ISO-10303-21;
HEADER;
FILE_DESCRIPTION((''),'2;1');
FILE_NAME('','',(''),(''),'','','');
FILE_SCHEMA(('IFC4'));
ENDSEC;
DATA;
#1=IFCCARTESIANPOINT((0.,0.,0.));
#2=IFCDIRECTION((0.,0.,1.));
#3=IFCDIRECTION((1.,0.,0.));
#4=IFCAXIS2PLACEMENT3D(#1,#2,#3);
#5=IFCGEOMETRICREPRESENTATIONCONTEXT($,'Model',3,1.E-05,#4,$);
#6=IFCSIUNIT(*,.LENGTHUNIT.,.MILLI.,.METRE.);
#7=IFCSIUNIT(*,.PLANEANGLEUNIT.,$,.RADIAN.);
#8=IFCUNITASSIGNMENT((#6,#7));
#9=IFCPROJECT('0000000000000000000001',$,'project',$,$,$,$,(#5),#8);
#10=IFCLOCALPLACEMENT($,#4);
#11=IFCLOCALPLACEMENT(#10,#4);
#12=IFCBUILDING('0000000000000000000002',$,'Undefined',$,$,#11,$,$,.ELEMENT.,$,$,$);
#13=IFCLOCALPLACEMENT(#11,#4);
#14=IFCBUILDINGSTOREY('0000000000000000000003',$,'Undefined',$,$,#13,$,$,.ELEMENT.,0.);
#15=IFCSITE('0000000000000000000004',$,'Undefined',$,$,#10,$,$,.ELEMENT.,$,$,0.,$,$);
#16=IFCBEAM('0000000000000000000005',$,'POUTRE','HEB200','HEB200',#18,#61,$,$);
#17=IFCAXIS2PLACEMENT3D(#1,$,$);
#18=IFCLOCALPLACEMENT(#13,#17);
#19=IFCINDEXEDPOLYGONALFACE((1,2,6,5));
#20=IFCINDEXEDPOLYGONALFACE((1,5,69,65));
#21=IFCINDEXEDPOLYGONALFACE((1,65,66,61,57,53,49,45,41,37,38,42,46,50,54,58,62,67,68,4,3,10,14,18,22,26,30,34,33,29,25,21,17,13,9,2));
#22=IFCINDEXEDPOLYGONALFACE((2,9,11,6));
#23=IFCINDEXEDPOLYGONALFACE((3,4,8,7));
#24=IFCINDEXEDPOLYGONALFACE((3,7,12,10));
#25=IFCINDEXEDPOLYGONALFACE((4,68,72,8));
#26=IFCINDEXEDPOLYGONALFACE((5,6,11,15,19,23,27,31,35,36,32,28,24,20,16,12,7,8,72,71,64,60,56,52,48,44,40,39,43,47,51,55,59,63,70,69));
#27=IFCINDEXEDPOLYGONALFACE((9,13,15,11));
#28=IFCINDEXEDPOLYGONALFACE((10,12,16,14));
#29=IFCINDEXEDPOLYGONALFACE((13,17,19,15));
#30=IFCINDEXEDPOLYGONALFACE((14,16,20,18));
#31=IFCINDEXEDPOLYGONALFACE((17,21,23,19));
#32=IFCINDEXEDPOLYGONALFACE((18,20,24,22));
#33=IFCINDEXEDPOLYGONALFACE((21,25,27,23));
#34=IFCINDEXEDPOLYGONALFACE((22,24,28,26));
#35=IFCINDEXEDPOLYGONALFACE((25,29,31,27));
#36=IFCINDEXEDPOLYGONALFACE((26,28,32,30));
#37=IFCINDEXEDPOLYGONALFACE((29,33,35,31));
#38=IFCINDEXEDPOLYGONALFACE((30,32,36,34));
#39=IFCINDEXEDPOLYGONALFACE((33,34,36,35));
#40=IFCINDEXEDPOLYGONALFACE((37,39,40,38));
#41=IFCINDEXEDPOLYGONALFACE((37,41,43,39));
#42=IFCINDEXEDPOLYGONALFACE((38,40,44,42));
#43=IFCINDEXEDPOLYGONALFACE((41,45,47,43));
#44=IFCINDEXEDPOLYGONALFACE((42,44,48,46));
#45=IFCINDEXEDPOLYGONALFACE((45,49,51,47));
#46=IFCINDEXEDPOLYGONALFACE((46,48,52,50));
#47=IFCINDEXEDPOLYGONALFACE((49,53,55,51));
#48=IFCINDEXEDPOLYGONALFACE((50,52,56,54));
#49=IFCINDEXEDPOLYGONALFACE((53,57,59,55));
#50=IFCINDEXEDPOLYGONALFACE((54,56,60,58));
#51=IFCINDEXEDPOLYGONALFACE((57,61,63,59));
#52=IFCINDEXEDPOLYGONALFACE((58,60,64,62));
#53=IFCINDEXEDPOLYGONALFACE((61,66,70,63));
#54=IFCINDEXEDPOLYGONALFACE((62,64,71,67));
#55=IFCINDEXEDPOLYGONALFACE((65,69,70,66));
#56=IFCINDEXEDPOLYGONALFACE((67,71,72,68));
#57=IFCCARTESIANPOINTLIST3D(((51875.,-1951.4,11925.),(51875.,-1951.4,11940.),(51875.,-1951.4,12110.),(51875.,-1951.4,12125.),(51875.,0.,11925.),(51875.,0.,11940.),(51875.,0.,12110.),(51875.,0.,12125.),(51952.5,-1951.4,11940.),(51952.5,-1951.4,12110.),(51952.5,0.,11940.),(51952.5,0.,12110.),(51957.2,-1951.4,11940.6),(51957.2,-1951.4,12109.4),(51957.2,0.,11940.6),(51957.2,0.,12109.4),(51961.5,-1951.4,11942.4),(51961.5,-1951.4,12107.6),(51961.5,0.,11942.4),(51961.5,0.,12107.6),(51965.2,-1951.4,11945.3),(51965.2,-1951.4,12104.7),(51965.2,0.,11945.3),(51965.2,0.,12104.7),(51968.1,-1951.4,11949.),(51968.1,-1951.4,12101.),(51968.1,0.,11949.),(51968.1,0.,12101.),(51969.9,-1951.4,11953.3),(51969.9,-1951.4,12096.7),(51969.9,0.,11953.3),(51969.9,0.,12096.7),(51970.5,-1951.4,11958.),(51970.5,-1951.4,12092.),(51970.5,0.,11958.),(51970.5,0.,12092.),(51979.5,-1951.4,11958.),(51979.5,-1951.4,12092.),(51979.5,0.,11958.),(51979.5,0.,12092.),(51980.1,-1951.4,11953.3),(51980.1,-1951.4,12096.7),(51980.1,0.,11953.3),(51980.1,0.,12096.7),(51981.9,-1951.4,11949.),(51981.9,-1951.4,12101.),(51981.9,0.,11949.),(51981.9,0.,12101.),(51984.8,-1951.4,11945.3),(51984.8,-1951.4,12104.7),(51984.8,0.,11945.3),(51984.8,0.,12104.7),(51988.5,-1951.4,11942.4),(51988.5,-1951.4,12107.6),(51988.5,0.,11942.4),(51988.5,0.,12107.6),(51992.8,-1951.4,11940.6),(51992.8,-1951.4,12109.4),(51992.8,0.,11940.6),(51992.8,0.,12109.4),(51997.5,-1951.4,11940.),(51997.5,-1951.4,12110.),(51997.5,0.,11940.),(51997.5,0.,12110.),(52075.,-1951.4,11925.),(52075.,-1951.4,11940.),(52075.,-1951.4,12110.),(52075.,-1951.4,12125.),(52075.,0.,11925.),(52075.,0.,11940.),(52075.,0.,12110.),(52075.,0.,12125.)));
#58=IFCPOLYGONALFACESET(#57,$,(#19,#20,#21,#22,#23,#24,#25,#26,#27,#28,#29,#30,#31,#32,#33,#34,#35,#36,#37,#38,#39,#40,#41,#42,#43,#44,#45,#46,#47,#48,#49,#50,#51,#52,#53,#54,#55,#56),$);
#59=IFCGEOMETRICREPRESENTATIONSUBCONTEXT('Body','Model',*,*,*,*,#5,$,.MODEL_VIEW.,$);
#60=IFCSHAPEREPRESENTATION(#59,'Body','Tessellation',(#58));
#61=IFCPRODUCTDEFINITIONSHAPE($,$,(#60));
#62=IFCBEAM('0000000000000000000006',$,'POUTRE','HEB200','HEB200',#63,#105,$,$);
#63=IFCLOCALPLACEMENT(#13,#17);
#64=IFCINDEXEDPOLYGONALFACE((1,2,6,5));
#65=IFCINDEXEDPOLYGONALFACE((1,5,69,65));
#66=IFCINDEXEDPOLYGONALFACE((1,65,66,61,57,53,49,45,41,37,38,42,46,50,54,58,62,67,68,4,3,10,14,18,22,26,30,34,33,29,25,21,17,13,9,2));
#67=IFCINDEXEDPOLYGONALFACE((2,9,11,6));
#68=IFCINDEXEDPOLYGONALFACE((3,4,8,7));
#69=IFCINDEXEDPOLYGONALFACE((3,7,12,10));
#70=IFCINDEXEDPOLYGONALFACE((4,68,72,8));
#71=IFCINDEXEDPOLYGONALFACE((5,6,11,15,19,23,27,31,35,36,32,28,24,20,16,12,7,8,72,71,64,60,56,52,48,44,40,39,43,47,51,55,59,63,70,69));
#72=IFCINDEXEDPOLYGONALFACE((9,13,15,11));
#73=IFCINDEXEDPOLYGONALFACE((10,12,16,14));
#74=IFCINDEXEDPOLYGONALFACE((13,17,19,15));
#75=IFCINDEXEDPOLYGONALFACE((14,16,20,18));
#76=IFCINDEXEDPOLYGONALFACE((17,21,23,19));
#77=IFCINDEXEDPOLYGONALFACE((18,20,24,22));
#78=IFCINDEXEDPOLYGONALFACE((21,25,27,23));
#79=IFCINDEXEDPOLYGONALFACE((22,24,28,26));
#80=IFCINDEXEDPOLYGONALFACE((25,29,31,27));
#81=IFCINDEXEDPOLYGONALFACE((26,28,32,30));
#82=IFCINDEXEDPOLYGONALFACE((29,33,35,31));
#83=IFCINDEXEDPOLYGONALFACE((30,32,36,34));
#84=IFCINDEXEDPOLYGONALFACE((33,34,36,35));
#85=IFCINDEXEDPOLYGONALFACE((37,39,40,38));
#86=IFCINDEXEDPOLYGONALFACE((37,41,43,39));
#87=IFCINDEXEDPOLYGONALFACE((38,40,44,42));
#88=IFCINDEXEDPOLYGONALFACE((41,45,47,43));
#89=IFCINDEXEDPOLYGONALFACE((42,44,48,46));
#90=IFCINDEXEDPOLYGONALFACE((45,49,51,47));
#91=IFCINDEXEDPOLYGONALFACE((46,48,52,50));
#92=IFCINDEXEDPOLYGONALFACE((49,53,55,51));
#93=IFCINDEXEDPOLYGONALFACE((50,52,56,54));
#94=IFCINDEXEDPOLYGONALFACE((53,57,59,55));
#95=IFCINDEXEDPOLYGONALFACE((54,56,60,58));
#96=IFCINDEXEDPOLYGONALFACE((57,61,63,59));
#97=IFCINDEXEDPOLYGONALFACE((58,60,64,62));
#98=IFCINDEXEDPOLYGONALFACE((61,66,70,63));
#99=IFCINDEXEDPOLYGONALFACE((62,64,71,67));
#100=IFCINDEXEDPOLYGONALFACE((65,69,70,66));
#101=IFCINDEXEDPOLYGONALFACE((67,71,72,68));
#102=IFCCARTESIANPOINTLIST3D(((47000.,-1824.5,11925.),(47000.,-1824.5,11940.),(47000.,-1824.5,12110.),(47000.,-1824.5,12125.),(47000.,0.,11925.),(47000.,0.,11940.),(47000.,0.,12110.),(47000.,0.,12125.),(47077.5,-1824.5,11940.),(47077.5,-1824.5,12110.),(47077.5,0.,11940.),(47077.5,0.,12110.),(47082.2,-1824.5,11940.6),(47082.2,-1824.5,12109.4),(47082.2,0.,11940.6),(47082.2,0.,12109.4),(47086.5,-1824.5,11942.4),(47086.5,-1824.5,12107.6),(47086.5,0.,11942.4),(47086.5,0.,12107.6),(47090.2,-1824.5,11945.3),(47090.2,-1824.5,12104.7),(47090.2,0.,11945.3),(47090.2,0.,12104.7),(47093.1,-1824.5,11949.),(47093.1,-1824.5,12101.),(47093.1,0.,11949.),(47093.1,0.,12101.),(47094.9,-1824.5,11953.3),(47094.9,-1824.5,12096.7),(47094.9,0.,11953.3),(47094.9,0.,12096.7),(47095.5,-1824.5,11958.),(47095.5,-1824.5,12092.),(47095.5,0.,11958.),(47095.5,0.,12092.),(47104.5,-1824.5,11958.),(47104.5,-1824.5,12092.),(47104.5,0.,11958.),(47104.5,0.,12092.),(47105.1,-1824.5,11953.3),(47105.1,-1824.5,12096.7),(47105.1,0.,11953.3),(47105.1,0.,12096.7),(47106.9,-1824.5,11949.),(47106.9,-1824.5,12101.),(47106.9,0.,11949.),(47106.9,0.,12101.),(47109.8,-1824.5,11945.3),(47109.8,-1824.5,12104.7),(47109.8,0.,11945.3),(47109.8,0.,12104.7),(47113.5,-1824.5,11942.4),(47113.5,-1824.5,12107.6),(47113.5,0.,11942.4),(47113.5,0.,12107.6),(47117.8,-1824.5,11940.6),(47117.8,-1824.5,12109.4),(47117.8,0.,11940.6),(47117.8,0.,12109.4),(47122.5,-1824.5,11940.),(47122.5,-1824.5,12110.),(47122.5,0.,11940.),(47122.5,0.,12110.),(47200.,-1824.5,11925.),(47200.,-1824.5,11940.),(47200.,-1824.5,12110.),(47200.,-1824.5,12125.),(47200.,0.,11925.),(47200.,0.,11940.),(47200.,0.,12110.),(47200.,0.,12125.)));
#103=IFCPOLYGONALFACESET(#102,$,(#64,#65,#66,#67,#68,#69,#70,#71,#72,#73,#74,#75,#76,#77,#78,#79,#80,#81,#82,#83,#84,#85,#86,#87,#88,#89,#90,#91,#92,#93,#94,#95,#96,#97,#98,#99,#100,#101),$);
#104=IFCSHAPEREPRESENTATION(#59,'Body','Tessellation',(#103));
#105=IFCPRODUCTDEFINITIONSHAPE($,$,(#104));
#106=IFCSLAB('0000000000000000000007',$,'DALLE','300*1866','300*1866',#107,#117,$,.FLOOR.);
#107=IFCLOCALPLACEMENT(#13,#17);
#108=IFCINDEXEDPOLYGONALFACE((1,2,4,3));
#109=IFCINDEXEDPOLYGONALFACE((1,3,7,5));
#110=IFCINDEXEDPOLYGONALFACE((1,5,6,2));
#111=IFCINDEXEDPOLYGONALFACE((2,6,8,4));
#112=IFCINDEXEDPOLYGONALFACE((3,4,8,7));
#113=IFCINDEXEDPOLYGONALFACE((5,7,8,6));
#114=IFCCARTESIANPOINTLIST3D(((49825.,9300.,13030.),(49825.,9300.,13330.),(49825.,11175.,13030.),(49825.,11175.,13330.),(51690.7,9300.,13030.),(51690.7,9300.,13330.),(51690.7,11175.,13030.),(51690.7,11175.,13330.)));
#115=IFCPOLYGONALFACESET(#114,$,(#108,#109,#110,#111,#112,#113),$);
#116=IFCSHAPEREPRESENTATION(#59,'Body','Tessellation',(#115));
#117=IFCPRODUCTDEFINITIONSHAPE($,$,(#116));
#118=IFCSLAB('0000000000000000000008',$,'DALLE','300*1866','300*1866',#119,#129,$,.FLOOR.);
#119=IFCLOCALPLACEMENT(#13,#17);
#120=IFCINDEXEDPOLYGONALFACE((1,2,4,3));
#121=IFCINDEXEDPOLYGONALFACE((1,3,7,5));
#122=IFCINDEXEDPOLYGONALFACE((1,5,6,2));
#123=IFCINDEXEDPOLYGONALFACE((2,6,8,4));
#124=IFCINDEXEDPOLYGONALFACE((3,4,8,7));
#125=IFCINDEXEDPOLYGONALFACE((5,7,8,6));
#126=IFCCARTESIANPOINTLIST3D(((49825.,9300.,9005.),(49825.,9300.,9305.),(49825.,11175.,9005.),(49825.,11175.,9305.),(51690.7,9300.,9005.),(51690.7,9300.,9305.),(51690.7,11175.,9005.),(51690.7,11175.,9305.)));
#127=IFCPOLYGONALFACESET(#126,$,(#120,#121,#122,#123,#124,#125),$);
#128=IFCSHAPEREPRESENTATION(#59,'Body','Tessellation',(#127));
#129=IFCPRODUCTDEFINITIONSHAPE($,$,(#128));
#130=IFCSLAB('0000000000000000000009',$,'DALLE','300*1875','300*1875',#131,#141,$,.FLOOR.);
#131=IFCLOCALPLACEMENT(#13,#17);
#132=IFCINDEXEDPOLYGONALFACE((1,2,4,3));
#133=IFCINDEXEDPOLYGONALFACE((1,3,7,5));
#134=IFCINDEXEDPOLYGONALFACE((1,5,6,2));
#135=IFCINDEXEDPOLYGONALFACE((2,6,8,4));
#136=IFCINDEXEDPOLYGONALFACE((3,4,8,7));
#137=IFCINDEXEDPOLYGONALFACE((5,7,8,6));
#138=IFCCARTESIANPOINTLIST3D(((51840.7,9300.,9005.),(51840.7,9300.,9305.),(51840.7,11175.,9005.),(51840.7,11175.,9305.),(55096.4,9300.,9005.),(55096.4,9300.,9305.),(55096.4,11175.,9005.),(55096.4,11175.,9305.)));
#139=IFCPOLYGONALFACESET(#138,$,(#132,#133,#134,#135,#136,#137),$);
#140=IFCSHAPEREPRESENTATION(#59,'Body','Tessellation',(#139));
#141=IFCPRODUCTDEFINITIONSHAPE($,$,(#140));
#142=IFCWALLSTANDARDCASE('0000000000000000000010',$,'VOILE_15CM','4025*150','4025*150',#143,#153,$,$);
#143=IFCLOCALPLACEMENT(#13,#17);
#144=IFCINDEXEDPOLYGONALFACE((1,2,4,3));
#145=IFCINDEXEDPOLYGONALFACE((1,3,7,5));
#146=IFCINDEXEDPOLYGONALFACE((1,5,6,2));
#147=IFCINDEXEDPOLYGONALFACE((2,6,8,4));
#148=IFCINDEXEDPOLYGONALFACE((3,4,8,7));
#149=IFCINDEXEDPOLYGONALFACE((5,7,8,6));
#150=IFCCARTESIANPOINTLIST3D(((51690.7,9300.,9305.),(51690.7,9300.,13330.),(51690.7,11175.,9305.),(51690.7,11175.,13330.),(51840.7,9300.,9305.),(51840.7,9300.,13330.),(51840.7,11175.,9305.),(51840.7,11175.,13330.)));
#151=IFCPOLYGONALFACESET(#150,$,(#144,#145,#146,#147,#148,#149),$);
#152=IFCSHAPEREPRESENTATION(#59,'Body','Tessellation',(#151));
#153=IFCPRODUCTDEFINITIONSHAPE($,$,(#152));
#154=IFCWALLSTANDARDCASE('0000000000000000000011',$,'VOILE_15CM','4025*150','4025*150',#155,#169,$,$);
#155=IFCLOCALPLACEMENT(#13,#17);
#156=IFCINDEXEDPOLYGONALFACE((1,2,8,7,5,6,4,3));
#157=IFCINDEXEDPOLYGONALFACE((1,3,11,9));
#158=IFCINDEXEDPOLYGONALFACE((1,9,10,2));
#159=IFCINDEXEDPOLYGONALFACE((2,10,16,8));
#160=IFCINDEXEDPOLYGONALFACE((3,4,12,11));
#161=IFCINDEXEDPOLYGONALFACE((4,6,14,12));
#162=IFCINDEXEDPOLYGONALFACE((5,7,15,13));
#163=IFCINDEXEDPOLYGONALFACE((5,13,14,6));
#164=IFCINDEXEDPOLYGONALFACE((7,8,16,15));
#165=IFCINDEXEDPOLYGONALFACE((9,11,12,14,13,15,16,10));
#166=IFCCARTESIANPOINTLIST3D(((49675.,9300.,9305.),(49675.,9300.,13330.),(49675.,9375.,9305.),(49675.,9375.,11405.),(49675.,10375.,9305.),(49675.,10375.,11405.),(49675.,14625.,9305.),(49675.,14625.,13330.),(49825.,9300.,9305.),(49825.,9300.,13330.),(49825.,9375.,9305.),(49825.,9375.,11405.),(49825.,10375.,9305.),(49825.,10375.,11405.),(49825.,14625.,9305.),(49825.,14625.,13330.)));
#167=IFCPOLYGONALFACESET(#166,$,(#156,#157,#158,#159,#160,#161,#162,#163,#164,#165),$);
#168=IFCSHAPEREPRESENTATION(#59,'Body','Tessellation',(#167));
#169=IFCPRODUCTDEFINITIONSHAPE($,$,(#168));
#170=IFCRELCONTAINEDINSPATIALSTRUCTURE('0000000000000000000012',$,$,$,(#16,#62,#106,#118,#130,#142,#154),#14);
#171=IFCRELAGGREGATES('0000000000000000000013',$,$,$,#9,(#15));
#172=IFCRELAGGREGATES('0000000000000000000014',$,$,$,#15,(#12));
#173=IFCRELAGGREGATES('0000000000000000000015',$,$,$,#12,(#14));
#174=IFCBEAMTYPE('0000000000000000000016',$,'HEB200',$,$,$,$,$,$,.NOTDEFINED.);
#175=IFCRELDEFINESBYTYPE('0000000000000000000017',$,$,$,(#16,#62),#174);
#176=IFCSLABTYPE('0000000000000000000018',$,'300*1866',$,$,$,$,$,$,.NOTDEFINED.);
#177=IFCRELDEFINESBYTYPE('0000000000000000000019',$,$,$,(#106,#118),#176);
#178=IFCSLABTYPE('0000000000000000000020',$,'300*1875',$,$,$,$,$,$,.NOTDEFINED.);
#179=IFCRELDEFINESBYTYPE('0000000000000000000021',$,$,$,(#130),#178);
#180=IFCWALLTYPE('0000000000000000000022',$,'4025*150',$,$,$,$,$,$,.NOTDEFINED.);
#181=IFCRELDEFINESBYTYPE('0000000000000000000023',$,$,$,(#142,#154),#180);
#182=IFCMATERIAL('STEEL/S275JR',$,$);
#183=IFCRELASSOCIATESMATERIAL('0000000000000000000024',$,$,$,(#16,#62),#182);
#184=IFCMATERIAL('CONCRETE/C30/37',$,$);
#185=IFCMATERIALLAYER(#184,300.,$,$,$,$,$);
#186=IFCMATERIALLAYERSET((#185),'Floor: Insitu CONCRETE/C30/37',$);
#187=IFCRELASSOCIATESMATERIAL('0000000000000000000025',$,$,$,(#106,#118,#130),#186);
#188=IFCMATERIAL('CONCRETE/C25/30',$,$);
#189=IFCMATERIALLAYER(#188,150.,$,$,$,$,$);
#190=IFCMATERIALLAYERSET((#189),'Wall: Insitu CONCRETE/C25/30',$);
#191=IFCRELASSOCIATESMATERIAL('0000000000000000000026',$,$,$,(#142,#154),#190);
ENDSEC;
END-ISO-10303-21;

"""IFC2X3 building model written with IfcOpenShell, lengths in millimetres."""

from ifc_helpers import new_model, si_unit, frame, frame_2d, origin_with_axes, origin_2d_with_axis, place, context, subcontext, project, spatial, polyline, rectangle, i_section, outline, extrude, boolean, material, layer, layer_set, layer_usage, type_object, element, save


model = new_model("IFC2X3")

# Units and contexts
model_context = context("Model", 3, precision=1e-05, world=origin_with_axes())
body_context = subcontext(model_context, "Body", "Model", "MODEL_VIEW")
ifc_project = project(units=[si_unit("LENGTHUNIT", "METRE", prefix="MILLI"), si_unit("PLANEANGLEUNIT", "RADIAN")], contexts=[model_context])

# Site, building, storey
site_placement = place(None, origin_with_axes())
site = spatial("IfcSite", under=ifc_project, at=site_placement, Name="Undefined", CompositionType="ELEMENT", RefElevation=0.0)
building_placement = place(site_placement, origin_with_axes())
building = spatial("IfcBuilding", under=site, at=building_placement, Name="Undefined", CompositionType="ELEMENT")
storey_placement = place(building_placement, origin_with_axes())
storey = spatial("IfcBuildingStorey", under=building, at=storey_placement, Name="Undefined", CompositionType="ELEMENT", Elevation=0.0)

# Shared definitions
ifc_material_1 = material(Name="CONCRETE/C25/30")
ifc_material_2 = material(Name="STEEL/S275JR")

# Beams
beam_type_1 = type_object("IfcBeamType", Name="HEB200", PredefinedType="NOTDEFINED")
beam_1_placement = place(storey_placement, frame((51975.0, 0.0, 12025.0), z_axis=(0.0, 0.0, 1.0), x_axis=(0.0, -1.0, 0.0)))
element("IfcBeam", 1, at=beam_1_placement, inside=storey, type_object=beam_type_1, material=ifc_material_2, Name="POUTRE", Description="HEB200", ObjectType="HEB200", context=body_context, shape_type="SweptSolid", body=[
    extrude(i_section(OverallWidth=200.0, OverallDepth=200.0, WebThickness=9.0, FlangeThickness=15.0, FilletRadius=18.0, at=origin_2d_with_axis()), frame((1951.4, 0.0, 0.0), z_axis=(-1.0, 0.0, 0.0), x_axis=(0.0, -1.0, 0.0)), (0.0, 0.0, 1.0), 1951.4),
])
beam_2_placement = place(storey_placement, frame((47100.0, 0.0, 12025.0), z_axis=(0.0, 0.0, 1.0), x_axis=(0.0, -1.0, 0.0)))
element("IfcBeam", 2, at=beam_2_placement, inside=storey, type_object=beam_type_1, material=ifc_material_2, Name="POUTRE", Description="HEB200", ObjectType="HEB200", context=body_context, shape_type="SweptSolid", body=[
    extrude(i_section(OverallWidth=200.0, OverallDepth=200.0, WebThickness=9.0, FlangeThickness=15.0, FilletRadius=18.0, at=origin_2d_with_axis()), frame((1824.5, 0.0, 0.0), z_axis=(-1.0, 0.0, 0.0), x_axis=(0.0, -1.0, 0.0)), (0.0, 0.0, 1.0), 1824.5),
])

# Slabs
ifc_material_3 = material(Name="CONCRETE/C30/37")
ifc_layer_1 = layer(ifc_material_3, 300.0)
ifc_layer_set_1 = layer_set([ifc_layer_1], Name="Floor: Insitu CONCRETE/C30/37")
ifc_layer_usage_1 = layer_usage(ifc_layer_set_1, "AXIS3", "POSITIVE", -150.0)
slab_type_1 = type_object("IfcSlabType", Name="300*1866", PredefinedType="NOTDEFINED")
slab_1_placement = place(storey_placement, frame((51690.7, 11175.0, 13180.0), z_axis=(0.0, 0.0, 1.0), x_axis=(-1.0, 0.0, 0.0)))
element("IfcSlab", 3, at=slab_1_placement, inside=storey, type_object=slab_type_1, material=ifc_layer_usage_1, Name="DALLE", Description="300*1866", ObjectType="300*1866", PredefinedType="FLOOR", context=body_context, shape_type="SweptSolid", body=[
    extrude(outline(polyline([(0.0, 0.0), (1865.7, 0.0), (1865.7, 1875.0), (0.0, 1875.0), (0.0, 0.0)])), frame((0.0, 0.0, -150.0), z_axis=(0.0, 0.0, 1.0), x_axis=(1.0, 0.0, 0.0)), (0.0, 0.0, 1.0), 300.0),
])
ifc_layer_usage_2 = layer_usage(ifc_layer_set_1, "AXIS3", "POSITIVE", -150.0)
slab_2_placement = place(storey_placement, frame((51690.7, 11175.0, 9155.0), z_axis=(0.0, 0.0, 1.0), x_axis=(-1.0, 0.0, 0.0)))
element("IfcSlab", 4, at=slab_2_placement, inside=storey, type_object=slab_type_1, material=ifc_layer_usage_2, Name="DALLE", Description="300*1866", ObjectType="300*1866", PredefinedType="FLOOR", context=body_context, shape_type="SweptSolid", body=[
    extrude(outline(polyline([(0.0, 0.0), (1865.7, 0.0), (1865.7, 1875.0), (0.0, 1875.0), (0.0, 0.0)])), frame((0.0, 0.0, -150.0), z_axis=(0.0, 0.0, 1.0), x_axis=(1.0, 0.0, 0.0)), (0.0, 0.0, 1.0), 300.0),
])
ifc_layer_usage_3 = layer_usage(ifc_layer_set_1, "AXIS3", "POSITIVE", -150.0)
slab_type_2 = type_object("IfcSlabType", Name="300*1875", PredefinedType="NOTDEFINED")
slab_3_placement = place(storey_placement, frame((55096.4, 11175.0, 9155.0), z_axis=(0.0, 0.0, 1.0), x_axis=(-1.0, 0.0, 0.0)))
element("IfcSlab", 5, at=slab_3_placement, inside=storey, type_object=slab_type_2, material=ifc_layer_usage_3, Name="DALLE", Description="300*1875", ObjectType="300*1875", PredefinedType="FLOOR", context=body_context, shape_type="SweptSolid", body=[
    extrude(outline(polyline([(0.0, 0.0), (3255.7, 0.0), (3255.7, 1875.0), (0.0, 1875.0), (0.0, 0.0)])), frame((0.0, 0.0, -150.0), z_axis=(0.0, 0.0, 1.0), x_axis=(1.0, 0.0, 0.0)), (0.0, 0.0, 1.0), 300.0),
])

# Walls
ifc_layer_2 = layer(ifc_material_1, 150.0)
ifc_layer_set_2 = layer_set([ifc_layer_2], Name="Wall: Insitu CONCRETE/C25/30")
ifc_layer_usage_4 = layer_usage(ifc_layer_set_2, "AXIS2", "POSITIVE", -75.0)
wall_type_1 = type_object("IfcWallType", Name="4025*150", PredefinedType="NOTDEFINED")
wall_1_placement = place(storey_placement, frame((51765.7, 9300.0, 9305.0), z_axis=(0.0, 0.0, 1.0), x_axis=(0.0, 1.0, 0.0)))
element("IfcWallStandardCase", 6, at=wall_1_placement, inside=storey, type_object=wall_type_1, material=ifc_layer_usage_4, Name="VOILE_15CM", Description="4025*150", ObjectType="4025*150", context=body_context, shape_type="SweptSolid", body=[
    extrude(rectangle(XDim=1875.0, YDim=150.0, at=frame_2d((0.0, 937.5), x_axis=(0.0, -1.0))), frame((0.0, 0.0, 0.0), z_axis=(0.0, 0.0, 1.0), x_axis=(0.0, -1.0, 0.0)), (0.0, 0.0, 1.0), 4025.0),
])
ifc_layer_usage_5 = layer_usage(ifc_layer_set_2, "AXIS2", "POSITIVE", -75.0)
wall_2_placement = place(storey_placement, frame((49750.0, 9300.0, 9305.0), z_axis=(0.0, 0.0, 1.0), x_axis=(0.0, 1.0, 0.0)))
element("IfcWallStandardCase", 7, at=wall_2_placement, inside=storey, type_object=wall_type_1, material=ifc_layer_usage_5, Name="VOILE_15CM", Description="4025*150", ObjectType="4025*150", context=body_context, shape_type="CSG", body=[
    boolean("DIFFERENCE", extrude(rectangle(XDim=5325.0, YDim=150.0, at=frame_2d((0.0, 2662.5), x_axis=(0.0, -1.0))), frame((0.0, 0.0, 0.0), z_axis=(0.0, 0.0, 1.0), x_axis=(0.0, -1.0, 0.0)), (0.0, 0.0, 1.0), 4025.0), extrude(outline(polyline([(0.0, 0.0), (2100.0, 0.0), (2100.0, 1000.0), (0.0, 1000.0), (0.0, 0.0)])), frame((75.0, 85.0, 2100.0), z_axis=(0.0, -1.0, 0.0), x_axis=(0.0, 0.0, -1.0)), (0.0, 0.0, 1.0), 170.0)),
])

save(model, "model.ifc")
